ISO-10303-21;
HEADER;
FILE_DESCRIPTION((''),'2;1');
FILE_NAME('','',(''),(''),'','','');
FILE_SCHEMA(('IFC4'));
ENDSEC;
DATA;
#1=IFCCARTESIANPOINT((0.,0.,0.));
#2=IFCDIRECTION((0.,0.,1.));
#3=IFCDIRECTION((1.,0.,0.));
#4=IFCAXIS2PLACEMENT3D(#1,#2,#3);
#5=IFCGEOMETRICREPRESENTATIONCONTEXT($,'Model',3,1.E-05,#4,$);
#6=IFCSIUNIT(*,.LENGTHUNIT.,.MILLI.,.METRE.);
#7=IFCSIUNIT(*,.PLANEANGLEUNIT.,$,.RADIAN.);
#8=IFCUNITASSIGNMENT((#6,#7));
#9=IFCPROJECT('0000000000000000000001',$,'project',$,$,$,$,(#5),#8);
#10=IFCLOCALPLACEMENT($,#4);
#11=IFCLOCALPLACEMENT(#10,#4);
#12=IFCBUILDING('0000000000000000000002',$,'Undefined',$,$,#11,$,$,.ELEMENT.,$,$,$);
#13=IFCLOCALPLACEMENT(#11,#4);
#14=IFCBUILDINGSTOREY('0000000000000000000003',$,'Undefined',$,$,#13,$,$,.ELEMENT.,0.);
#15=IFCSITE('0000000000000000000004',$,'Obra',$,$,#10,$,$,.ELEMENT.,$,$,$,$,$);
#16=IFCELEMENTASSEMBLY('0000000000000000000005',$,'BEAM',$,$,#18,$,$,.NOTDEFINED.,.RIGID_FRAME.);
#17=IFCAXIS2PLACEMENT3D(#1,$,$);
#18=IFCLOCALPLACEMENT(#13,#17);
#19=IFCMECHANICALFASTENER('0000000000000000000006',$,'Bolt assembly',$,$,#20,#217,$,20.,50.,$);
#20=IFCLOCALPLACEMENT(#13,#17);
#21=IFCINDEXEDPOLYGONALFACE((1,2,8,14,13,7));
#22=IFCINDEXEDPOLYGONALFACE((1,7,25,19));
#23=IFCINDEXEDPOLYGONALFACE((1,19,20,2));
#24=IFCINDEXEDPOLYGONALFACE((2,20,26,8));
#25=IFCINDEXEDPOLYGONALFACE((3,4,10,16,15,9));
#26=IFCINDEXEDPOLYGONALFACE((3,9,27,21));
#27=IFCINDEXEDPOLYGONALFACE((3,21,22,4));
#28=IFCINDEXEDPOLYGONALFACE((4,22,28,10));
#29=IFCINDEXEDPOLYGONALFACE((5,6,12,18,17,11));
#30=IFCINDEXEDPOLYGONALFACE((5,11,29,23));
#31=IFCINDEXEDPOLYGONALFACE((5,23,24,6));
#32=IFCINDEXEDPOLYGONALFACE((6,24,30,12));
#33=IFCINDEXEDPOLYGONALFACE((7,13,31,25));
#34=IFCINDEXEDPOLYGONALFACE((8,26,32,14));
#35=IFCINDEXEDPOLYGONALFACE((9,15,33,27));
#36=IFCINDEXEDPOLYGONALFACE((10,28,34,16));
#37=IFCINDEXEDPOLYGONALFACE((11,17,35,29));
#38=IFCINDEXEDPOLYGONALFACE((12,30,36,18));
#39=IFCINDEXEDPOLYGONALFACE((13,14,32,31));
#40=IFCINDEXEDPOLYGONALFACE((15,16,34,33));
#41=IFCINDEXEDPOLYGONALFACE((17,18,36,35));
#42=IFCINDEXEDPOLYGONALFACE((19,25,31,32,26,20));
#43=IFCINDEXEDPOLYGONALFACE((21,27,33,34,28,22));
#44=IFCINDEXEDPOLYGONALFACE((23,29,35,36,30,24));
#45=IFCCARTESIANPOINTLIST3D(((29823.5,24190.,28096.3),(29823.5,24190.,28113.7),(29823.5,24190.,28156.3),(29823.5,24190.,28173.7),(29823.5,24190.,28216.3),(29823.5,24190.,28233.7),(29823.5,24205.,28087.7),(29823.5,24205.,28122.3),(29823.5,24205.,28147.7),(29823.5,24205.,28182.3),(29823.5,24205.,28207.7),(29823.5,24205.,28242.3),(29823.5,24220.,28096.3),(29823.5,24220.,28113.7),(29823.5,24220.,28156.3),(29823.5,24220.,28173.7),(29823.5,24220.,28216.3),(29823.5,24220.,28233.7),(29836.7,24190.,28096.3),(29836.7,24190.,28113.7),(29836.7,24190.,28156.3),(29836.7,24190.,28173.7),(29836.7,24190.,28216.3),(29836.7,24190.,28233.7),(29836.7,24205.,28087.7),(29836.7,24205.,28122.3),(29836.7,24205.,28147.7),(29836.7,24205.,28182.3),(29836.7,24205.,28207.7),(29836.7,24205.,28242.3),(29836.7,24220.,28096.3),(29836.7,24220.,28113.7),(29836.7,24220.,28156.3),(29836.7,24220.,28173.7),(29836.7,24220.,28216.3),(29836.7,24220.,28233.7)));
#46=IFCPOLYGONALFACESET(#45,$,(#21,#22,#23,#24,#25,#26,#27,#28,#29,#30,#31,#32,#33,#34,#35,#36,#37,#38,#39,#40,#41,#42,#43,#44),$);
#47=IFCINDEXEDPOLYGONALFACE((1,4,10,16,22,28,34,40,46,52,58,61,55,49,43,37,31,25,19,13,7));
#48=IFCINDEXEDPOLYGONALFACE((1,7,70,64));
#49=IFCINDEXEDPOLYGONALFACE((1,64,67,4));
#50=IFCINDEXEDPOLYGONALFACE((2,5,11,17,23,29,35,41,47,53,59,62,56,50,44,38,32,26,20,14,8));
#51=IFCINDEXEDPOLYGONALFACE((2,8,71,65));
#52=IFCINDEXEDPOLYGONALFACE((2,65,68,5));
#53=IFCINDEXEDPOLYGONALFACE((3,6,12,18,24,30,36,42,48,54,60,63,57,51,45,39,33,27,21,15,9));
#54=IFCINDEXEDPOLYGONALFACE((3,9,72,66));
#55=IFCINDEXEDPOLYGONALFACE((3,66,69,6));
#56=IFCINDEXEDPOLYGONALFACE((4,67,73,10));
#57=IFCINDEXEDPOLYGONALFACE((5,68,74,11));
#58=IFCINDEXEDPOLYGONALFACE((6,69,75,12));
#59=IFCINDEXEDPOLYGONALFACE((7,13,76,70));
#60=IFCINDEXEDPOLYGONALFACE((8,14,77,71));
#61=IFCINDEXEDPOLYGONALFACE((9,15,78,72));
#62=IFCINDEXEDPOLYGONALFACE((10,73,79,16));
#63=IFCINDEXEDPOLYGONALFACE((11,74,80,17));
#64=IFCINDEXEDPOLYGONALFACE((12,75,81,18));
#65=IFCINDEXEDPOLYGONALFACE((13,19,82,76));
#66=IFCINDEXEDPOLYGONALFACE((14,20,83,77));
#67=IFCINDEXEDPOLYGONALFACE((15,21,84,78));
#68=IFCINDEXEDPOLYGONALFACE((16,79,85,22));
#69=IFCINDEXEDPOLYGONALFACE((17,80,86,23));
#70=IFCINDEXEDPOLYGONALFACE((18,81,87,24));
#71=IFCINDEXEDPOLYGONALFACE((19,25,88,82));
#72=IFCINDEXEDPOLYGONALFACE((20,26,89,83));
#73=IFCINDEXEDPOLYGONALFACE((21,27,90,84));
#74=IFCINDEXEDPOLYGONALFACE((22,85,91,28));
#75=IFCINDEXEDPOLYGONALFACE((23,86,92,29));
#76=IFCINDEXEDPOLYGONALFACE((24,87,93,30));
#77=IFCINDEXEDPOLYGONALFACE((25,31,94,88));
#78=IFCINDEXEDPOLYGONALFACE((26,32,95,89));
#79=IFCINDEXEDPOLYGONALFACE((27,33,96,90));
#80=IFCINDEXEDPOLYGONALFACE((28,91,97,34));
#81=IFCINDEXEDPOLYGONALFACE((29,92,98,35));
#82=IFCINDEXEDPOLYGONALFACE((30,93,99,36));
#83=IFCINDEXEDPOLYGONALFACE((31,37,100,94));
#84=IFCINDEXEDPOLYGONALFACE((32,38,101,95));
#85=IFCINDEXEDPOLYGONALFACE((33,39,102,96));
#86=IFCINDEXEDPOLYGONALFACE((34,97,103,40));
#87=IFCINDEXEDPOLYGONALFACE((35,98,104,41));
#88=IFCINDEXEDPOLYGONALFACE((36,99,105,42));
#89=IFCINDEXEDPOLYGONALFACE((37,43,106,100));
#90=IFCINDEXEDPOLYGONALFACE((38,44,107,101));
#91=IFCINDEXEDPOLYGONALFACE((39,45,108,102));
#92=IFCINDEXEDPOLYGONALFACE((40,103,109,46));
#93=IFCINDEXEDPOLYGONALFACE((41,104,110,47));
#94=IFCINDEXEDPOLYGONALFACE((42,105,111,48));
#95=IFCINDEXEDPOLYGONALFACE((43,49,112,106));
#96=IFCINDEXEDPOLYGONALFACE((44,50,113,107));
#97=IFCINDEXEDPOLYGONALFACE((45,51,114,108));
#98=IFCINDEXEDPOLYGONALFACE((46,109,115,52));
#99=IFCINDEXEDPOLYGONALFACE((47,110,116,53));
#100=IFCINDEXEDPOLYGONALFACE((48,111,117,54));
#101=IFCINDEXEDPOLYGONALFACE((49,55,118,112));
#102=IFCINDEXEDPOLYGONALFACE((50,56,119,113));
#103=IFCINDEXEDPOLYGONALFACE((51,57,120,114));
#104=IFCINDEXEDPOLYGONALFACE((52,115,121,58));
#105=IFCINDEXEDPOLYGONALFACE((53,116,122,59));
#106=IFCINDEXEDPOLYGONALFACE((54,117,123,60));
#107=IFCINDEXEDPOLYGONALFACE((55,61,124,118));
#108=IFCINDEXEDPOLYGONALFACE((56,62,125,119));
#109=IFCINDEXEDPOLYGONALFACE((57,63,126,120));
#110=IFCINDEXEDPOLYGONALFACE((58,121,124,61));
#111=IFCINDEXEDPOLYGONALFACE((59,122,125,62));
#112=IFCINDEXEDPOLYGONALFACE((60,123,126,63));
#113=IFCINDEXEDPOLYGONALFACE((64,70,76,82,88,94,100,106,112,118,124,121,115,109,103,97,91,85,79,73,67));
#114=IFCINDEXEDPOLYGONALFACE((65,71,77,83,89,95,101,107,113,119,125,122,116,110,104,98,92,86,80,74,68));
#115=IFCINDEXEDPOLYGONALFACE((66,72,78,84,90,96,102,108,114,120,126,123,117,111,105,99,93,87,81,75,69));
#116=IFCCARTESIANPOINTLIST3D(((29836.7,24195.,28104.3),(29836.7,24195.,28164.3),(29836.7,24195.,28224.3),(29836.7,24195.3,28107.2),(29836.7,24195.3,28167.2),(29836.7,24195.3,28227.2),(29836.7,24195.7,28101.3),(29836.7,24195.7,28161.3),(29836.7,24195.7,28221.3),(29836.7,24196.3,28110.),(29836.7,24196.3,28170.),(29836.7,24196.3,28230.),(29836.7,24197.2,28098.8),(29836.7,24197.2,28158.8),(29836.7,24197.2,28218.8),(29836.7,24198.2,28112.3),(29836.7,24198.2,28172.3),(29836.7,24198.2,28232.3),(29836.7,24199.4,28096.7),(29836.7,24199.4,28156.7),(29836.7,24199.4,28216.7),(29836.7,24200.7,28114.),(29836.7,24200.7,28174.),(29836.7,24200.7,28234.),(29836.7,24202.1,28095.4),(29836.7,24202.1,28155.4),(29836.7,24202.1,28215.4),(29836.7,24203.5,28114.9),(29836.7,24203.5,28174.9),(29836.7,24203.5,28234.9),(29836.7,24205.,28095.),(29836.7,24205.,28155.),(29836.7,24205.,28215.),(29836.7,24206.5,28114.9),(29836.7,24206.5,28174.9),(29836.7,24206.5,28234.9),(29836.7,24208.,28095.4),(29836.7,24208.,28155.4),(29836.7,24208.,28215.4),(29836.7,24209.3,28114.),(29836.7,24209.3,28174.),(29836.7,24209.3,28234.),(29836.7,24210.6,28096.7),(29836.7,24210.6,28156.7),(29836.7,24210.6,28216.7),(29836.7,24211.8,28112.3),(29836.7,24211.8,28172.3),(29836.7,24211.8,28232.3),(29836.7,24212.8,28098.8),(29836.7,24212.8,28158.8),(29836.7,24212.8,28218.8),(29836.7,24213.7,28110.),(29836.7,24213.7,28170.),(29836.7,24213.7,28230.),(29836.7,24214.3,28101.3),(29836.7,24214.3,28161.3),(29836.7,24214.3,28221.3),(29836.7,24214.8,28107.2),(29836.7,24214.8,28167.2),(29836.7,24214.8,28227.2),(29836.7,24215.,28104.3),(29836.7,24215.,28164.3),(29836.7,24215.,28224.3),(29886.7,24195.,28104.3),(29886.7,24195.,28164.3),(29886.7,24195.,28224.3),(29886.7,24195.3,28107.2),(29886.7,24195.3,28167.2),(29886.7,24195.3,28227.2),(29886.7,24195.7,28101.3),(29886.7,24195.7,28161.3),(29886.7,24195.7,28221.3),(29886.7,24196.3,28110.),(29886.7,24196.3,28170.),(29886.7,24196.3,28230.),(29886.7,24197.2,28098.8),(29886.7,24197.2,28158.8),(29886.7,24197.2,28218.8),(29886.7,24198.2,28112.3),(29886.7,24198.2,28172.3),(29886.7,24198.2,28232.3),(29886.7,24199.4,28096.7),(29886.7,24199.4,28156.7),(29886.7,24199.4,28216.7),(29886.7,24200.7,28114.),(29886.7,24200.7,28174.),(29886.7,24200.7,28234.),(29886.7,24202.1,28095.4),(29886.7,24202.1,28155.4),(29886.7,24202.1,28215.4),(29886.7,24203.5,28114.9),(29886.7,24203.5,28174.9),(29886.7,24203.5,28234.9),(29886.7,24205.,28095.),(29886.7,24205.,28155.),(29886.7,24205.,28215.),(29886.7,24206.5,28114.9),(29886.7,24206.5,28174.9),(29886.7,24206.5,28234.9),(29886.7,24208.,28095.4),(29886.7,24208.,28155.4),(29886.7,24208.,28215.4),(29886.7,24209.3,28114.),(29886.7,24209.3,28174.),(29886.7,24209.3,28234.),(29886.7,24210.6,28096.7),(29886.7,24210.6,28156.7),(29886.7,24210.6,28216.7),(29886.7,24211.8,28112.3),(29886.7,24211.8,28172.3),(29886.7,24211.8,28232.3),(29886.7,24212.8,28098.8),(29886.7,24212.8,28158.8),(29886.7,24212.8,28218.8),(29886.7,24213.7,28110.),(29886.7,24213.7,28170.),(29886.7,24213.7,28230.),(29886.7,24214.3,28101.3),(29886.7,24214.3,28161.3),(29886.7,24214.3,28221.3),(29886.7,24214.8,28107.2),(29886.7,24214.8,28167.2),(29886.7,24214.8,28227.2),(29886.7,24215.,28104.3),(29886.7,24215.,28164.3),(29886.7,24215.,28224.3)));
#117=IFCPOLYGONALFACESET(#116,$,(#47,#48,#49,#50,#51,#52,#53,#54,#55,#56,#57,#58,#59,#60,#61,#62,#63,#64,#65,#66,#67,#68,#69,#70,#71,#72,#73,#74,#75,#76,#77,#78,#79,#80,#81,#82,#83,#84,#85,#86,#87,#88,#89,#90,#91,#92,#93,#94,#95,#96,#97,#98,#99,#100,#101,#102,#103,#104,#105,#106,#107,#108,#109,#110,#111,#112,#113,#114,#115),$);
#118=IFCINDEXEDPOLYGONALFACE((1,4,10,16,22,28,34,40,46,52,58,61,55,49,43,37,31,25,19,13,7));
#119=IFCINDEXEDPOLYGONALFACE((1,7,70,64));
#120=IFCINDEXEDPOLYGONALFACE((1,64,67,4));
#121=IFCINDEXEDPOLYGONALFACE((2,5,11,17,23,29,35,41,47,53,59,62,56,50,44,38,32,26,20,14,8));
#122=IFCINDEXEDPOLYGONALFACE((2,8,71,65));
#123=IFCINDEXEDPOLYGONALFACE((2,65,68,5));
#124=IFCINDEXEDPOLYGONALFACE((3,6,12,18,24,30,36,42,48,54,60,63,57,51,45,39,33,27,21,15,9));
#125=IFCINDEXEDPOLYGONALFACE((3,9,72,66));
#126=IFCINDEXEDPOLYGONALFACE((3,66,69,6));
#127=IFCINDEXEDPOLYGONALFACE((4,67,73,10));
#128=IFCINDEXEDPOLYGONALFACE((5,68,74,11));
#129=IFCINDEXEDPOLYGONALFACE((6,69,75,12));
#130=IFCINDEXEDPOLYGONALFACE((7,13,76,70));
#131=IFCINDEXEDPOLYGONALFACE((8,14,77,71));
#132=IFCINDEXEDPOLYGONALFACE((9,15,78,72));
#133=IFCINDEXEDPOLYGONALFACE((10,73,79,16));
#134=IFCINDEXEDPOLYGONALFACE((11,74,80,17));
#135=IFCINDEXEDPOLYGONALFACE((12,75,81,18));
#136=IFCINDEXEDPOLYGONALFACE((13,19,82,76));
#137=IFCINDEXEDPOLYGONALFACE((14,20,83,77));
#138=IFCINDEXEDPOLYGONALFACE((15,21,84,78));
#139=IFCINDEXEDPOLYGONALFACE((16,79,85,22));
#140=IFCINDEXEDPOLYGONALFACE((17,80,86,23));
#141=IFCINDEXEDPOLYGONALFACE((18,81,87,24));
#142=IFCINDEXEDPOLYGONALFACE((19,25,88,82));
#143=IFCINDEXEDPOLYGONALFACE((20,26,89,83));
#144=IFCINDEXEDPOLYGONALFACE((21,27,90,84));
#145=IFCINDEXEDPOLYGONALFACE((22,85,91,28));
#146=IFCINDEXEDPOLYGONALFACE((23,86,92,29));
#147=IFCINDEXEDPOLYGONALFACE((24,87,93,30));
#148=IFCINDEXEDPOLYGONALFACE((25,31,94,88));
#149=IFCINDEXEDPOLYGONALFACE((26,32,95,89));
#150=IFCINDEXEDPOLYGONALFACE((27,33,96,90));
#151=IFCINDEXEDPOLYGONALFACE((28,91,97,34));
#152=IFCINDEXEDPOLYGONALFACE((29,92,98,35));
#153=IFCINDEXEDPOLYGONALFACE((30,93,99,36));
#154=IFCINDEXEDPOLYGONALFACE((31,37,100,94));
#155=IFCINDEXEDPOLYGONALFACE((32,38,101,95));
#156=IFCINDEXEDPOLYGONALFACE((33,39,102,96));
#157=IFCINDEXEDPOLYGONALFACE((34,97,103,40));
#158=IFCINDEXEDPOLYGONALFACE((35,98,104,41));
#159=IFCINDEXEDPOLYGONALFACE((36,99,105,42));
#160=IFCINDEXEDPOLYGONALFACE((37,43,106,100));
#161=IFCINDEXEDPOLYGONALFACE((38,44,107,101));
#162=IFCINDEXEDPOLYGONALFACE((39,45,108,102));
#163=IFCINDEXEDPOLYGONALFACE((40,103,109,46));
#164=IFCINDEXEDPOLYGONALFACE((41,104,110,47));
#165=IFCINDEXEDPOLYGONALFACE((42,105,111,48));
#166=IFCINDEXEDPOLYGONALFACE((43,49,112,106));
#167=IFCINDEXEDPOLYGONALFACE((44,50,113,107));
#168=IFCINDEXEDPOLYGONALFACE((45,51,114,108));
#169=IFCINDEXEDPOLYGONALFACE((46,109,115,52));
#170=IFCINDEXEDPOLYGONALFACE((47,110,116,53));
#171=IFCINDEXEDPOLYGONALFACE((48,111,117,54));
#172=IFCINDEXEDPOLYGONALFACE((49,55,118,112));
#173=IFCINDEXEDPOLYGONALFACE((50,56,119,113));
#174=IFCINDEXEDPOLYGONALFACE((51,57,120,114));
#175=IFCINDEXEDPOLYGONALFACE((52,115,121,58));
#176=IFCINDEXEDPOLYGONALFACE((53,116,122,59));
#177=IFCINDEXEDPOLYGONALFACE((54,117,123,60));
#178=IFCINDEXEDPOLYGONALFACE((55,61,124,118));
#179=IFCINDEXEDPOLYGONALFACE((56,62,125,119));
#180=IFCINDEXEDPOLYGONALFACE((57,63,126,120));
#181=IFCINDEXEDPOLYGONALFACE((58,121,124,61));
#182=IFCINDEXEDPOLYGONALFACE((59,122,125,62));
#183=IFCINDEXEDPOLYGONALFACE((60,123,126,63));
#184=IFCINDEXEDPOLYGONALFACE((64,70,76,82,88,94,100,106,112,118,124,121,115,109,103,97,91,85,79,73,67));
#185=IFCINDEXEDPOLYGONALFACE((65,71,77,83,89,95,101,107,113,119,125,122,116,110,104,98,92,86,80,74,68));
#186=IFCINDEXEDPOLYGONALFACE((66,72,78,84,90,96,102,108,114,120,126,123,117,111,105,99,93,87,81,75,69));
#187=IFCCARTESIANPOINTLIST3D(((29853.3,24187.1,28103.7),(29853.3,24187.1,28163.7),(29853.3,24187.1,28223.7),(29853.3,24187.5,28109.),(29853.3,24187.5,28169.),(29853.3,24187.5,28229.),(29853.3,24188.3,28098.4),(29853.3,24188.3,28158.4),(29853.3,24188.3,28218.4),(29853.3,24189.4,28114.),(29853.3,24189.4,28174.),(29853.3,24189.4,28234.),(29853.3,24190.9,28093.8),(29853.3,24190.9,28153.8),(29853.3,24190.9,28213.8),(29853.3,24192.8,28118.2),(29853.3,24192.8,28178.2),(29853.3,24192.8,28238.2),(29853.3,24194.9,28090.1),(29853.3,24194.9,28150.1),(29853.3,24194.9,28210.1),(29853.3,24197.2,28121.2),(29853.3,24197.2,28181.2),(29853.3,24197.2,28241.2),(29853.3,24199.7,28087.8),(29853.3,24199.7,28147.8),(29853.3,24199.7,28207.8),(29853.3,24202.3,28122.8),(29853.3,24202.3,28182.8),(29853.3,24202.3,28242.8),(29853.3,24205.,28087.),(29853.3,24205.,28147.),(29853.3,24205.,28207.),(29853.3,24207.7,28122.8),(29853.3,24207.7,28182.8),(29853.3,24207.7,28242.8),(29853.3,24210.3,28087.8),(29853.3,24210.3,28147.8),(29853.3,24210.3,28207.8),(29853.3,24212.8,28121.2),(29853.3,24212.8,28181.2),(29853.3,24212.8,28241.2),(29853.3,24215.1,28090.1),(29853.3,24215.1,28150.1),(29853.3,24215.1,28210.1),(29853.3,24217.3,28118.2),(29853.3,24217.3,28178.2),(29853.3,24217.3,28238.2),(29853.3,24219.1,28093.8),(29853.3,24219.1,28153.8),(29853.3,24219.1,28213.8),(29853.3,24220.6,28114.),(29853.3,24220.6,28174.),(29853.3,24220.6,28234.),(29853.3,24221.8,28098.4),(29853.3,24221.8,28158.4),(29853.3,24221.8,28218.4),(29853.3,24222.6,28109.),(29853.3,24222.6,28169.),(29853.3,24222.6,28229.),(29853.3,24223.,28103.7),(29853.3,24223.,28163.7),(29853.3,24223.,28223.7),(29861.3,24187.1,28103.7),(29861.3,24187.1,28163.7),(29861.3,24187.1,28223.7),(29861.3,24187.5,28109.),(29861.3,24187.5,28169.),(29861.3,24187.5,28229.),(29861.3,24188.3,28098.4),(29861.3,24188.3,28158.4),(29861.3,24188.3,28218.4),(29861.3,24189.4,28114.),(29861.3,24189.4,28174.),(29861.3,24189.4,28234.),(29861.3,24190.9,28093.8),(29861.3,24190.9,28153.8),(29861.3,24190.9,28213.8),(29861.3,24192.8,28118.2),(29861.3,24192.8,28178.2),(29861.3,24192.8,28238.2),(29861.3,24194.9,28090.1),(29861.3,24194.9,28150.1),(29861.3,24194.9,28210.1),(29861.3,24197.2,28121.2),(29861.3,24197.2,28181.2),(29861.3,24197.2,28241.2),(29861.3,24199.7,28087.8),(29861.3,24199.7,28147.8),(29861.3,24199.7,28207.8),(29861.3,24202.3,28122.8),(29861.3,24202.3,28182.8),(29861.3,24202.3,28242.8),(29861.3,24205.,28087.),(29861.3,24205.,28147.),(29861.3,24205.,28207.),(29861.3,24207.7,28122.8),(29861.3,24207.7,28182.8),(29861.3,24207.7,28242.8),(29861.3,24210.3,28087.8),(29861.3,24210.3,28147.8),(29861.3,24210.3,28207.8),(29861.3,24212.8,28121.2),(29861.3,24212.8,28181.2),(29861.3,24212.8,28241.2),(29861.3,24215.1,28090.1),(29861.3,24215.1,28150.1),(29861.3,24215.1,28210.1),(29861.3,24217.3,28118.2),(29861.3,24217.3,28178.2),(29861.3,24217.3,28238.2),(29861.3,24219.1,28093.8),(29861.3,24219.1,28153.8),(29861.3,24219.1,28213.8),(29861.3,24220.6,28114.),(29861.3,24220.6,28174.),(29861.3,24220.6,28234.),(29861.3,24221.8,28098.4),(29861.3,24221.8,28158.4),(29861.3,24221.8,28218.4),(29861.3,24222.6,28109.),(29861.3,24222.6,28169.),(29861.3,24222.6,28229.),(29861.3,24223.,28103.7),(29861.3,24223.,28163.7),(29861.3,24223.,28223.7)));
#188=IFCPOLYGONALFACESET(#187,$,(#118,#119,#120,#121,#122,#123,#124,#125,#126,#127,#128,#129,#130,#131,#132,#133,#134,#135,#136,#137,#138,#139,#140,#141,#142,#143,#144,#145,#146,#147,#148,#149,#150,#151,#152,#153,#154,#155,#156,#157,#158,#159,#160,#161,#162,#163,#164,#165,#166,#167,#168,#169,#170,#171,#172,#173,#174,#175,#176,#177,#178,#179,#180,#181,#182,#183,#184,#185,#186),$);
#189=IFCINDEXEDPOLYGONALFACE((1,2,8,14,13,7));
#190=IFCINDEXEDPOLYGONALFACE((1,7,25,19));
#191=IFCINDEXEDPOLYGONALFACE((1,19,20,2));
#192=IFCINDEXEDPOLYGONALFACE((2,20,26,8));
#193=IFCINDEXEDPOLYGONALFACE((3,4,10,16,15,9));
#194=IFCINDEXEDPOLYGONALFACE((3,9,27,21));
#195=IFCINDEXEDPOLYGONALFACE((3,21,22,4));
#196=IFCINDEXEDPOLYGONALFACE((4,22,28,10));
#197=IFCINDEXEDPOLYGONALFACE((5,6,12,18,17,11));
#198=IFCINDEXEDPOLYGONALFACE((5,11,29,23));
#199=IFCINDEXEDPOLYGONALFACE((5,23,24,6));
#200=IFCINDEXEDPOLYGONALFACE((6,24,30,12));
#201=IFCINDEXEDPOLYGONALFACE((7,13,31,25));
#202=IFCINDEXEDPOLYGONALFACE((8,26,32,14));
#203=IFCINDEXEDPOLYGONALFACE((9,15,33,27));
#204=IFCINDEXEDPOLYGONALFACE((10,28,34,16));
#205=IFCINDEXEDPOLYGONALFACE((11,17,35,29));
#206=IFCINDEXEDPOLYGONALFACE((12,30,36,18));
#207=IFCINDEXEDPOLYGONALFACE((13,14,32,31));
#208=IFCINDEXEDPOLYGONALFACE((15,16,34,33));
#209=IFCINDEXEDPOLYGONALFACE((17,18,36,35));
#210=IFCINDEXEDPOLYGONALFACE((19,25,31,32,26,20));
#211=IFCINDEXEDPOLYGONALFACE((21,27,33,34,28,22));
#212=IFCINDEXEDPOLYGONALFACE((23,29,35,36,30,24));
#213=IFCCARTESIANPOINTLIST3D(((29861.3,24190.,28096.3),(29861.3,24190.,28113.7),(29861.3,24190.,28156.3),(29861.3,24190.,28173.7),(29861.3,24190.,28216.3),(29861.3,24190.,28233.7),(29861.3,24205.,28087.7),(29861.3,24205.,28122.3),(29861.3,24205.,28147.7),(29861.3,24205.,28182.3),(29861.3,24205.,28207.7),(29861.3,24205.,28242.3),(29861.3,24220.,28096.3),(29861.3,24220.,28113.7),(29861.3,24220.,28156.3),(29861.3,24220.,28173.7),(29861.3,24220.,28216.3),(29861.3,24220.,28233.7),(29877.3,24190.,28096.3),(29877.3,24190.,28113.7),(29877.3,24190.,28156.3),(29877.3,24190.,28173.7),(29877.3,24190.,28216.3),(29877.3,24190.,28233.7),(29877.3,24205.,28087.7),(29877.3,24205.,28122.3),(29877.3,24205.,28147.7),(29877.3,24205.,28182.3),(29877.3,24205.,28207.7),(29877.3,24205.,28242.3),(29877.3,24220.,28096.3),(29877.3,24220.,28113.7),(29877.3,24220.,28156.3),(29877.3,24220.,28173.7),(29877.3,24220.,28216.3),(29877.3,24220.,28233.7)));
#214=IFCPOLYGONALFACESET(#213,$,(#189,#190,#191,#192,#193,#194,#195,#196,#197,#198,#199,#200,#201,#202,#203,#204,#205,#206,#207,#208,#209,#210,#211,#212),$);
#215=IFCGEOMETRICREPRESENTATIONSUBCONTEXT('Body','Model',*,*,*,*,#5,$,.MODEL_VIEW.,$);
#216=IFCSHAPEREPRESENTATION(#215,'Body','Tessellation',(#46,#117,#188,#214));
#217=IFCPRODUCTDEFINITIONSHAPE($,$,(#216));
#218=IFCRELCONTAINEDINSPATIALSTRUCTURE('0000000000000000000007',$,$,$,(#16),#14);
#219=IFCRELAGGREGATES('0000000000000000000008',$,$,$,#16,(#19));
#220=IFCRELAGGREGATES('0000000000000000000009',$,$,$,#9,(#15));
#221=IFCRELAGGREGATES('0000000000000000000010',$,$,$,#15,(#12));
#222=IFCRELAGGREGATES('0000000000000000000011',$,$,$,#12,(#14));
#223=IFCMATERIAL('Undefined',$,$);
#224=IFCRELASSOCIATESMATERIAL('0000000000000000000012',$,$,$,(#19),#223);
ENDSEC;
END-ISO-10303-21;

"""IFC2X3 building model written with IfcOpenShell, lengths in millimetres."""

from ifc_helpers import new_model, si_unit, frame, origin_with_axes, origin_2d_with_axis, place, context, subcontext, project, spatial, polyline, circle, outline, extrude, source, transform, mapped, material, element, aggregate, save


model = new_model("IFC2X3")

# Units and contexts
model_context = context("Model", 3, precision=1e-05, world=origin_with_axes())
body_context = subcontext(model_context, "Body", "Model", "MODEL_VIEW")
ifc_project = project(units=[si_unit("LENGTHUNIT", "METRE", prefix="MILLI"), si_unit("PLANEANGLEUNIT", "RADIAN")], contexts=[model_context])

# Site, building, storey
site_placement = place(None, origin_with_axes())
site = spatial("IfcSite", under=ifc_project, at=site_placement, Name="Obra", CompositionType="ELEMENT")
building_placement = place(site_placement, origin_with_axes())
building = spatial("IfcBuilding", under=site, at=building_placement, Name="Undefined", CompositionType="ELEMENT")
storey_placement = place(building_placement, origin_with_axes())
storey = spatial("IfcBuildingStorey", under=building, at=storey_placement, Name="Undefined", CompositionType="ELEMENT", Elevation=0.0)

# Shared definitions
ifc_material_1 = material(Name="Undefined")

# Element assembly, mechanical fastener
assembly_1_placement = place(storey_placement, origin_with_axes())
assembly_1 = element("IfcElementAssembly", 1, at=assembly_1_placement, inside=storey, Name="BEAM", AssemblyPlace="NOTDEFINED", PredefinedType="RIGID_FRAME")
shared_shape_1 = source(origin_with_axes(), body_context, "Body", "SweptSolid", [
    extrude(outline(polyline([(17.3, 0.0), (8.7, 15.0), (-8.7, 15.0), (-17.3, 0.0), (-8.7, -15.0), (8.7, -15.0), (17.3, 0.0)])), frame((0.0, -26.5, 0.0), z_axis=(0.0, 1.0, 0.0), x_axis=(1.0, 0.0, 0.0)), (0.0, 0.0, 1.0), 13.2),
    extrude(circle(Radius=10.0, at=origin_2d_with_axis()), frame((0.0, -13.3, 0.0), z_axis=(0.0, 1.0, 0.0), x_axis=(1.0, 0.0, 0.0)), (0.0, 0.0, 1.0), 50.0),
    extrude(circle(Radius=18.0, at=origin_2d_with_axis()), frame((0.0, 3.3, 0.0), z_axis=(0.0, 1.0, 0.0), x_axis=(1.0, 0.0, 0.0)), (0.0, 0.0, 1.0), 8.0),
    extrude(outline(polyline([(17.3, 0.0), (8.7, 15.0), (-8.7, 15.0), (-17.3, 0.0), (-8.7, -15.0), (8.7, -15.0), (17.3, 0.0)])), frame((0.0, 11.3, 0.0), z_axis=(0.0, 1.0, 0.0), x_axis=(1.0, 0.0, 0.0)), (0.0, 0.0, 1.0), 16.0),
])
mechanical_fastener_1_placement = place(assembly_1_placement, frame((29850.0, 24255.0, 28265.0), z_axis=(0.000001, -1.0, 0.0), x_axis=(0.0, 0.0, -1.0)))
mechanical_fastener_1 = element("IfcMechanicalFastener", 2, at=mechanical_fastener_1_placement, material=ifc_material_1, Name="Bolt assembly", NominalDiameter=20.0, NominalLength=50.0, context=body_context, shape_type="MappedRepresentation", body=[
    mapped(shared_shape_1, transform((40.0, 0.0, 50.0))),
    mapped(shared_shape_1, transform((100.0, 0.0, 50.0))),
    mapped(shared_shape_1, transform((160.0, 0.0, 50.0))),
])
aggregate(assembly_1, [mechanical_fastener_1])

save(model, "model.ifc")
